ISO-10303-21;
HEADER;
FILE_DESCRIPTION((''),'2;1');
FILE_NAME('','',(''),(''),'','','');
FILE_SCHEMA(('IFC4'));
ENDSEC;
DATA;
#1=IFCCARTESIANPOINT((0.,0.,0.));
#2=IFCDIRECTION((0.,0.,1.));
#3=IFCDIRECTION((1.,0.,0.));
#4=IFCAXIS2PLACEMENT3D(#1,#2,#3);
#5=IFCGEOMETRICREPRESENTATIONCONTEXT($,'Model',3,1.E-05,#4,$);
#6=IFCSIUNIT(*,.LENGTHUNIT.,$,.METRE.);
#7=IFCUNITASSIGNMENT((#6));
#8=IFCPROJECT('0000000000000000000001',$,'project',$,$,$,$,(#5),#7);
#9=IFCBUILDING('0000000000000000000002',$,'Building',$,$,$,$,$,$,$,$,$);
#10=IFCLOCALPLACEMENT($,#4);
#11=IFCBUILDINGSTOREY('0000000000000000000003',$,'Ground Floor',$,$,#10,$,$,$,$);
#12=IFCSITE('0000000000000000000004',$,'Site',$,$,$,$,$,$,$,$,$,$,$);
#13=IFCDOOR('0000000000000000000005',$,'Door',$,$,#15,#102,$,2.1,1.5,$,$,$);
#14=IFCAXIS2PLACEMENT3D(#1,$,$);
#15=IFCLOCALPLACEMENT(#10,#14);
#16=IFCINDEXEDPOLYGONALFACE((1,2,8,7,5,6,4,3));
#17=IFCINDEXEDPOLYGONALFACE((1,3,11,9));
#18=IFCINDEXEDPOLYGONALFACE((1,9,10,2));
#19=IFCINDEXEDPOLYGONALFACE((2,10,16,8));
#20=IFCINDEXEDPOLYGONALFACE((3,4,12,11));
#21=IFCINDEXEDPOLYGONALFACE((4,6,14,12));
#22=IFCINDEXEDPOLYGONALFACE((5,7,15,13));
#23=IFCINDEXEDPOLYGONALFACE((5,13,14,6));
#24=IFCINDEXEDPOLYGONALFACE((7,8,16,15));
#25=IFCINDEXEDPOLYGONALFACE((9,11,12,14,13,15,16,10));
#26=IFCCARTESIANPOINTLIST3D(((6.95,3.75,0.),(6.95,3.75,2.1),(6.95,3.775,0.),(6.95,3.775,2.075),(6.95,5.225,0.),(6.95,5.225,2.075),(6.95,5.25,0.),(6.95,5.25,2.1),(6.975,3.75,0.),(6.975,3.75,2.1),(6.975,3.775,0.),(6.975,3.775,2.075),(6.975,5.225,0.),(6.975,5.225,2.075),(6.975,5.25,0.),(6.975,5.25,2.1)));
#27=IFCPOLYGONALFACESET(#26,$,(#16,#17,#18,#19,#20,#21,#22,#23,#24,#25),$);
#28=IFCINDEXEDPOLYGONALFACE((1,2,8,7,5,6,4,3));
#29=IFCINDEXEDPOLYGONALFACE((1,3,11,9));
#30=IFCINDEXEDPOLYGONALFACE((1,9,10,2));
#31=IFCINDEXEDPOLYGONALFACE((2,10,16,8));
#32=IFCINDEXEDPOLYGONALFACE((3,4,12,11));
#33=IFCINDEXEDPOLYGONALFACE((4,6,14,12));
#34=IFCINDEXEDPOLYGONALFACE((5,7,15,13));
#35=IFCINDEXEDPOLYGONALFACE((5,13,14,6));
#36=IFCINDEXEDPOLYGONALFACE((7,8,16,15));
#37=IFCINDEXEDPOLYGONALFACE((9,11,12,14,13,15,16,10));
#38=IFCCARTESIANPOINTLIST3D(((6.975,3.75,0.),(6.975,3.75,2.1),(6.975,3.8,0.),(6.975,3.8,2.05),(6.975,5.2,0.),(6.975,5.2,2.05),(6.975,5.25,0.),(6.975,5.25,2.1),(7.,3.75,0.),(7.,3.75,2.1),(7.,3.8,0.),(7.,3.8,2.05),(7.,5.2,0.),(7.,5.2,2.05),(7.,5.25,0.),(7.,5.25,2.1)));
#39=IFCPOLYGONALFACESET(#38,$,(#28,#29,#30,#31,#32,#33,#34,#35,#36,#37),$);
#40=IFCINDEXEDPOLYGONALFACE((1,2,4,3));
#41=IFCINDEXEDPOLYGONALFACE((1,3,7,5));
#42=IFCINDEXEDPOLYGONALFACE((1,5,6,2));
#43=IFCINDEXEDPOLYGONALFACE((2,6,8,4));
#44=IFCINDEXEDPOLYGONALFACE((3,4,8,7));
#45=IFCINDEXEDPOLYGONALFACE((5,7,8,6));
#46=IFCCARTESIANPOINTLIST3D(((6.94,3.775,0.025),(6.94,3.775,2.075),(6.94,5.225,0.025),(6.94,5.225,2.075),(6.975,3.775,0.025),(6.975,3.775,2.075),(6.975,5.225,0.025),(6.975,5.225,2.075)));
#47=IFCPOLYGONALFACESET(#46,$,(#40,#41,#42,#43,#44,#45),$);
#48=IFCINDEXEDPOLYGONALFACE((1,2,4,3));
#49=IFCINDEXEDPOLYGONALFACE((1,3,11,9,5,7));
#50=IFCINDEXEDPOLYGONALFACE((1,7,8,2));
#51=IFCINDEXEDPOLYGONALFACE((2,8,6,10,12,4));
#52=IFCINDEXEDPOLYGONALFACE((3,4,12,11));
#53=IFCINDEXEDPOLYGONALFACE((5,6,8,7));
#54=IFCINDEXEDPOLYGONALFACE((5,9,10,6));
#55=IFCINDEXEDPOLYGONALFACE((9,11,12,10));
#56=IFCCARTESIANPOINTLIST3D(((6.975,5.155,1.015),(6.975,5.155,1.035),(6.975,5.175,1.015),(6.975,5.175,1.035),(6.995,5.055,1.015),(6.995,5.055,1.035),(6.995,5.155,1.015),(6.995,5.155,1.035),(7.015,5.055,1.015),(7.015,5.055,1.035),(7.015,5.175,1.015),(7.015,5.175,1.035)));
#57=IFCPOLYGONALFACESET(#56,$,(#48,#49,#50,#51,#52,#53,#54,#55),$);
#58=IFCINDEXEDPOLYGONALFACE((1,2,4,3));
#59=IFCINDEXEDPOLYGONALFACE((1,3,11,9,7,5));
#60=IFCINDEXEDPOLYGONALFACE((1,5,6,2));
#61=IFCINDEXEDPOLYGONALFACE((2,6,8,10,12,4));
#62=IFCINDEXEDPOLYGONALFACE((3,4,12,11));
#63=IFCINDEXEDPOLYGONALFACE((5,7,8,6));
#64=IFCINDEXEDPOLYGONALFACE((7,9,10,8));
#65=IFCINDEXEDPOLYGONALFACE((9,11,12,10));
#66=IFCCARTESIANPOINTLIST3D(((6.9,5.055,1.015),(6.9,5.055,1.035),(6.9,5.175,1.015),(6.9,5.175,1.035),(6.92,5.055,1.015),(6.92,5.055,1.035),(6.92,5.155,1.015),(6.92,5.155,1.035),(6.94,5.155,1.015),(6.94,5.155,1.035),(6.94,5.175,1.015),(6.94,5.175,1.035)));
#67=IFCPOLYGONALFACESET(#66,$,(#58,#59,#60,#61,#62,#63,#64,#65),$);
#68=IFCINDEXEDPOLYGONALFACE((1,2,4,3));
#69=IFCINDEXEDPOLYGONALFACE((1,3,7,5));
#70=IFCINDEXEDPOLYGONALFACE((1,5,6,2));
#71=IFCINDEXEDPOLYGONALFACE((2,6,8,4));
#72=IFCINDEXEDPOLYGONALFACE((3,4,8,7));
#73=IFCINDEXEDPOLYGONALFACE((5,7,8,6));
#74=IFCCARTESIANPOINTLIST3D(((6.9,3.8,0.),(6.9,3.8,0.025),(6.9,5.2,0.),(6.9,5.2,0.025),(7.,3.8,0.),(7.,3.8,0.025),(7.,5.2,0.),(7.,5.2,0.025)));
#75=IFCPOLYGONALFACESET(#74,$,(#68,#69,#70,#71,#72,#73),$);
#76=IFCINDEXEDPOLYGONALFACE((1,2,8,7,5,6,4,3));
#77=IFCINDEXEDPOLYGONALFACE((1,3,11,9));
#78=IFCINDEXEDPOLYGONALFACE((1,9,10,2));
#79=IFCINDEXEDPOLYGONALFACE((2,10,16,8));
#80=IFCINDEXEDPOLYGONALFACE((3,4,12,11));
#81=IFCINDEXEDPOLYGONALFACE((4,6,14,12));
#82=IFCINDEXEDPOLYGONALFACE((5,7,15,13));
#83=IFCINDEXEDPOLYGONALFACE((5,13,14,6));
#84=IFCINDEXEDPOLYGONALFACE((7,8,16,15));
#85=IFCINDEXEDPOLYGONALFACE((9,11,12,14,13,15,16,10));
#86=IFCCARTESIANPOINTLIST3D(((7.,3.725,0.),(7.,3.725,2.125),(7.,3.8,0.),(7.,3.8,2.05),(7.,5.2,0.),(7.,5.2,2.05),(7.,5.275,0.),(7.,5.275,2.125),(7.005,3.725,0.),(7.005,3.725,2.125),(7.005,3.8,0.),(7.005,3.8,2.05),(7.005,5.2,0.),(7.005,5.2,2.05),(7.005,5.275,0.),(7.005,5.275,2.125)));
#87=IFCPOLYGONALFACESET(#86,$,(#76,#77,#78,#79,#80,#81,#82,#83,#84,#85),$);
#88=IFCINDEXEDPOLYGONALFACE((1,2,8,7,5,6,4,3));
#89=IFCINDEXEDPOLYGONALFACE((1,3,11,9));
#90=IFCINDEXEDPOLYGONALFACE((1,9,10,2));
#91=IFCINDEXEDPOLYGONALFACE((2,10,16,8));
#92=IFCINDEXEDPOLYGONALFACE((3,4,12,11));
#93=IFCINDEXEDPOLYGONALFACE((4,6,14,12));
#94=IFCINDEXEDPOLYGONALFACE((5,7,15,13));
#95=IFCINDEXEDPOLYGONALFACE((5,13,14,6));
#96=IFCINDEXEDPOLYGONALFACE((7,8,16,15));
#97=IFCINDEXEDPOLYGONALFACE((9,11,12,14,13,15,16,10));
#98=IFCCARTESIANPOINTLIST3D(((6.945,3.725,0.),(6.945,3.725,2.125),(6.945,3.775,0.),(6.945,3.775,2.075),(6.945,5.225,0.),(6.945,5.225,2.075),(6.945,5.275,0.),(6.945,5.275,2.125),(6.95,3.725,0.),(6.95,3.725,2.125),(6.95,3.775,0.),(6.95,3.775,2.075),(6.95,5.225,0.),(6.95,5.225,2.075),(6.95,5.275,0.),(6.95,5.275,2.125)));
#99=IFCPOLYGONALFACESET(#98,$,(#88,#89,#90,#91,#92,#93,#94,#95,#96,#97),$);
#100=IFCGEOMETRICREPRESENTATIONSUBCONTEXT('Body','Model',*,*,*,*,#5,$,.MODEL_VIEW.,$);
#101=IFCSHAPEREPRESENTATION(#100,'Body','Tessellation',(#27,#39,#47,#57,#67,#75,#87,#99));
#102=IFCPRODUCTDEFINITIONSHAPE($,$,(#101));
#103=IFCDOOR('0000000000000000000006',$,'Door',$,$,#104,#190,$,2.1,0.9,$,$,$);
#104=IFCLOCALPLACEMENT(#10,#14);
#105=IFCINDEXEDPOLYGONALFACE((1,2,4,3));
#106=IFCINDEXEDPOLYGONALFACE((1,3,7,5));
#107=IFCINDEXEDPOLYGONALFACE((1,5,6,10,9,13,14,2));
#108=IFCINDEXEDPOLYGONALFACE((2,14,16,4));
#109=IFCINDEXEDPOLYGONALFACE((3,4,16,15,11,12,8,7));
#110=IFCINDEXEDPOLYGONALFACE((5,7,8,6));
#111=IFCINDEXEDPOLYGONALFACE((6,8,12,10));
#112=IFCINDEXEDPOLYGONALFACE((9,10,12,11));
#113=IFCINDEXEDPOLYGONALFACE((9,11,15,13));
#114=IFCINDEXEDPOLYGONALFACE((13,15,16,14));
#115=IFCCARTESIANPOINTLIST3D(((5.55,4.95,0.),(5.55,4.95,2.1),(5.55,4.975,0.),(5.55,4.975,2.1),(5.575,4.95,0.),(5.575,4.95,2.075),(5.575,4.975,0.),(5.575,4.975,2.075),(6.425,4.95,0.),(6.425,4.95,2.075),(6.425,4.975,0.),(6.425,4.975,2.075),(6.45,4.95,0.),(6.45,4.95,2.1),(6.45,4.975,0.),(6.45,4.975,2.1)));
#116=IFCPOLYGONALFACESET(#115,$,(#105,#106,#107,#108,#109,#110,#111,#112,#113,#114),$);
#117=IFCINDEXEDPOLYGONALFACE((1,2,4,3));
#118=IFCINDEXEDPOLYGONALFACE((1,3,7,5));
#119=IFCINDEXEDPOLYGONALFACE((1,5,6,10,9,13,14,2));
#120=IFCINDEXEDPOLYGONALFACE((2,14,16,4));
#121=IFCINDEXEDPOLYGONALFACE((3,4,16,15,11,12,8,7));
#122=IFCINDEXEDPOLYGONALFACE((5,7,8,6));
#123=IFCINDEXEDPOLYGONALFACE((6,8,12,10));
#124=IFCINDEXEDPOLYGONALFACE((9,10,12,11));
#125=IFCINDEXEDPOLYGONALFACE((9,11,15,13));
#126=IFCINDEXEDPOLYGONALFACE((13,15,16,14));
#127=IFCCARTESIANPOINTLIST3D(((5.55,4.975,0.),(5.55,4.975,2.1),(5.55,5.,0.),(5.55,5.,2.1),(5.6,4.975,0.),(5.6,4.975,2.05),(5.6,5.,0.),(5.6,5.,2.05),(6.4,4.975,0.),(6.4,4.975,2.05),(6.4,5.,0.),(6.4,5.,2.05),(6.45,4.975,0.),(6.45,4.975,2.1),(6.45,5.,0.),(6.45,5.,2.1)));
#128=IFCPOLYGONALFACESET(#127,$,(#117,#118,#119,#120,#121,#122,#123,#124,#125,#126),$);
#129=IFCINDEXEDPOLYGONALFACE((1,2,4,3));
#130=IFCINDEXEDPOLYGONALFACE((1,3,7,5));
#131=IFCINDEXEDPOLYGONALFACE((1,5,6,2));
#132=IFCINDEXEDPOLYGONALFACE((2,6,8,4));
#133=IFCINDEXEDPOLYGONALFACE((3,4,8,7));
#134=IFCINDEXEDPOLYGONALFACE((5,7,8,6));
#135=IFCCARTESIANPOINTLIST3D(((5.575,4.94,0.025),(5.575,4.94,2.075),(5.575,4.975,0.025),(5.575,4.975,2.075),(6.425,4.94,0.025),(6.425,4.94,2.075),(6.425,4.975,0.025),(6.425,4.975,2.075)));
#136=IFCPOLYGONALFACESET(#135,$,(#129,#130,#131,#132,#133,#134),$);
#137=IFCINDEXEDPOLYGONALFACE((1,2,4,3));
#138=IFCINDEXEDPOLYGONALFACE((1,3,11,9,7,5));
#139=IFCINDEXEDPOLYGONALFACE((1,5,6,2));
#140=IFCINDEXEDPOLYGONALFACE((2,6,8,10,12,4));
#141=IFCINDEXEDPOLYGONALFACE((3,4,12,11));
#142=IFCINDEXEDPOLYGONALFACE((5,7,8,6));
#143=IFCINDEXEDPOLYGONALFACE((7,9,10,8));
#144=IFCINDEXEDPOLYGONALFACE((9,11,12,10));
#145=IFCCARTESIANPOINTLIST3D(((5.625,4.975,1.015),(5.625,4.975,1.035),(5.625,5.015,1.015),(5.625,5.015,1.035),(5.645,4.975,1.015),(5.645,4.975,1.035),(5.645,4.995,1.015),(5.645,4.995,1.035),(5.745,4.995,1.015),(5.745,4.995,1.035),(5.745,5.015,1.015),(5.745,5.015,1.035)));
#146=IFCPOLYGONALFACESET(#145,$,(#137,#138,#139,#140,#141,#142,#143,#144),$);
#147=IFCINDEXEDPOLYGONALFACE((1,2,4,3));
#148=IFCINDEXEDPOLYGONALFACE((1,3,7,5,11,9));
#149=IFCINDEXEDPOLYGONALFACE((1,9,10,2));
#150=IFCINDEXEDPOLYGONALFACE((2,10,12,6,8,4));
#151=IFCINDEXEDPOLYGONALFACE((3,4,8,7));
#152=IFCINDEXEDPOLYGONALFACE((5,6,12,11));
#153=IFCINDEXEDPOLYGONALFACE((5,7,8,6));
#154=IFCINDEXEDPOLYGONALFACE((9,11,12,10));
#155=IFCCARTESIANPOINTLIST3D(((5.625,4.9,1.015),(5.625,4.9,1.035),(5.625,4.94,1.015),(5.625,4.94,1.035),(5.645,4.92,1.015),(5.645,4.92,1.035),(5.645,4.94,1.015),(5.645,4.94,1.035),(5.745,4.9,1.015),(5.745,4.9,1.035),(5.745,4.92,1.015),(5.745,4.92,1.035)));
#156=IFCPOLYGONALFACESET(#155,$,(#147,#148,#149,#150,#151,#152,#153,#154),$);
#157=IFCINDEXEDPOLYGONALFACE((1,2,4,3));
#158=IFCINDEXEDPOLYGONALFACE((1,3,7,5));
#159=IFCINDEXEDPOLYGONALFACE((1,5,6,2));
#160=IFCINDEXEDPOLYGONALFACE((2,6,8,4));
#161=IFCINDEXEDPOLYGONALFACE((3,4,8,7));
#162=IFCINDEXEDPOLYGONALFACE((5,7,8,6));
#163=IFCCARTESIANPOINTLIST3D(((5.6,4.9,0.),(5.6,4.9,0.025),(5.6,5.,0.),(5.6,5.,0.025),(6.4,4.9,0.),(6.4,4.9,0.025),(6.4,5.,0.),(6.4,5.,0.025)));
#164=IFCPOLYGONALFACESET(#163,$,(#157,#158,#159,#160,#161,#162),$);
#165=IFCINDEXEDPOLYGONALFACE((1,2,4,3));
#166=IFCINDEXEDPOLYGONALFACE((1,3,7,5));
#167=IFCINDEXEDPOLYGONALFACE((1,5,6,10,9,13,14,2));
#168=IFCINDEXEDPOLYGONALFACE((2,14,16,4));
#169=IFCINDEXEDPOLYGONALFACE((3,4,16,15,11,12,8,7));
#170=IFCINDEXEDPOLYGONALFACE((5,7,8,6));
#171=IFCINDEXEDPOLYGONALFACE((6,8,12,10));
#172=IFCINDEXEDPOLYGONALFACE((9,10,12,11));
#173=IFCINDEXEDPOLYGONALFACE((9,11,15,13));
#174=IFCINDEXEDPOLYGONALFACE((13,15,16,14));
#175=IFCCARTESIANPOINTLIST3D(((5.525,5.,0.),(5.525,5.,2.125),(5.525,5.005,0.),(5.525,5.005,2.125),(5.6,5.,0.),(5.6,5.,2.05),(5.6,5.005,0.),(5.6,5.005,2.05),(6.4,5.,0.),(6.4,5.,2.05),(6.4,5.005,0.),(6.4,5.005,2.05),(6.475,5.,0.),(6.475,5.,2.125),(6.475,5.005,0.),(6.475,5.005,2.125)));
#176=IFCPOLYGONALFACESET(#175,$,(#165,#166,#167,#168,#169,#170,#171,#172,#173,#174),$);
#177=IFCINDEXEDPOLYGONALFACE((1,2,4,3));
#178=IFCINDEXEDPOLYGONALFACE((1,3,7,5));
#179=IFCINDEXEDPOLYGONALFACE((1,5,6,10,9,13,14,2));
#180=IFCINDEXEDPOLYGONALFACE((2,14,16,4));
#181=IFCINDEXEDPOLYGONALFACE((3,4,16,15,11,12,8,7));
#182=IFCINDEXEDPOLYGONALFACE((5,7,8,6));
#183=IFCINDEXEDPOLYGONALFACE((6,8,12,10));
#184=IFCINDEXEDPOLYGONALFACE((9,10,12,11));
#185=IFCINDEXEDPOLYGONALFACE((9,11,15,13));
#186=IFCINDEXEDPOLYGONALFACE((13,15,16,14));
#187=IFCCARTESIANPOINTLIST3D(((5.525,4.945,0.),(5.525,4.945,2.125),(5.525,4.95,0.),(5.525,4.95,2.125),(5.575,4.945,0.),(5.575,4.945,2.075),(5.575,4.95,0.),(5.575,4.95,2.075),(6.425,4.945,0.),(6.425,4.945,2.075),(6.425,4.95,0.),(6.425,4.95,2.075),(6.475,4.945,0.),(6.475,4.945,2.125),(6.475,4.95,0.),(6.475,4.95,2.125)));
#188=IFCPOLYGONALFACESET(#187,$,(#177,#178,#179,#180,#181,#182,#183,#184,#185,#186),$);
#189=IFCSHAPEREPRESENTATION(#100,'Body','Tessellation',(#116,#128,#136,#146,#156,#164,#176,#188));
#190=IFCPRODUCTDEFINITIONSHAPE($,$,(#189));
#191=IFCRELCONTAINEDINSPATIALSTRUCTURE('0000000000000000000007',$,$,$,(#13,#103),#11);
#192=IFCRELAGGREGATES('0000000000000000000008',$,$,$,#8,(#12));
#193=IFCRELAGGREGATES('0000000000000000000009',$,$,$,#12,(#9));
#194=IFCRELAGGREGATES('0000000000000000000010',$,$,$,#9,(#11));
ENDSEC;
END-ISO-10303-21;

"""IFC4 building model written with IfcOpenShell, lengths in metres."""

from ifc_helpers import new_model, si_unit, frame, origin_with_axes, place, context, subcontext, project, spatial, line, indexed_curve, outline, extrude, element, save


model = new_model("IFC4")

# Units and contexts
model_context = context("Model", 3, precision=1e-05, world=origin_with_axes())
body_context = subcontext(model_context, "Body", "Model", "MODEL_VIEW")
ifc_project = project(units=[si_unit("LENGTHUNIT", "METRE")], contexts=[model_context])

# Site, building, storey
site = spatial("IfcSite", under=ifc_project, Name="Site")
building = spatial("IfcBuilding", under=site, Name="Building")
storey_placement = place(None, origin_with_axes())
storey = spatial("IfcBuildingStorey", under=building, at=storey_placement, Name="Ground Floor")

# Doors
door_1_placement = place(storey_placement, frame((7.0, 3.75, 0.0), z_axis=(0.0, 0.0, 1.0), x_axis=(0.0, 1.0, 0.0)))
element("IfcDoor", 1, at=door_1_placement, inside=storey, Name="Door", OverallHeight=2.1, OverallWidth=1.5, context=body_context, shape_type="SweptSolid", body=[
    extrude(outline(indexed_curve([(0.0, 0.0), (0.0, 2.1), (1.5, 2.1), (1.5, 0.0), (1.475, 0.0), (1.475, 2.075), (0.025, 2.075), (0.025, 0.0)], segments=[line(1, 2, 3, 4, 5, 6, 7, 8, 1)])), frame((0.0, 0.025, 0.0), z_axis=(0.0, -1.0, 0.0), x_axis=(1.0, 0.0, 0.0)), (0.0, 0.0, -1.0), 0.025),
    extrude(outline(indexed_curve([(0.0, 0.0), (0.0, 2.1), (1.5, 2.1), (1.5, 0.0), (1.45, 0.0), (1.45, 2.05), (0.05, 2.05), (0.05, 0.0)], segments=[line(1, 2, 3, 4, 5, 6, 7, 8, 1)])), frame((0.0, 0.0, 0.0), z_axis=(0.0, -1.0, 0.0), x_axis=(1.0, 0.0, 0.0)), (0.0, 0.0, -1.0), 0.025),
    extrude(outline(indexed_curve([(0.0, 0.0), (1.45, 0.0), (1.45, 0.035), (0.0, 0.035)], segments=[line(1, 2, 3, 4, 1)])), frame((0.025, 0.025, 0.025), z_axis=(0.0, 0.0, 1.0), x_axis=(1.0, 0.0, 0.0)), (0.0, 0.0, 1.0), 2.05),
    extrude(outline(indexed_curve([(0.0, 0.0), (0.0, -0.04), (-0.12, -0.04), (-0.12, -0.02), (-0.02, -0.02), (-0.02, 0.0)], segments=[line(1, 2, 3, 4, 5, 6, 1)])), frame((1.425, 0.025, 1.015), z_axis=(0.0, 0.0, 1.0), x_axis=(1.0, 0.0, 0.0)), (0.0, 0.0, 1.0), 0.02),
    extrude(outline(indexed_curve([(0.0, 0.0), (0.0, 0.04), (-0.12, 0.04), (-0.12, 0.02), (-0.02, 0.02), (-0.02, 0.0)], segments=[line(1, 2, 3, 4, 5, 6, 1)])), frame((1.425, 0.06, 1.015), z_axis=(0.0, 0.0, 1.0), x_axis=(1.0, 0.0, 0.0)), (0.0, 0.0, 1.0), 0.02),
    extrude(outline(indexed_curve([(0.0, 0.0), (1.4, 0.0), (1.4, 0.1), (0.0, 0.1)], segments=[line(1, 2, 3, 4, 1)])), frame((0.05, 0.0, 0.0), z_axis=(0.0, 0.0, 1.0), x_axis=(1.0, 0.0, 0.0)), (0.0, 0.0, 1.0), 0.025),
    extrude(outline(indexed_curve([(0.0, 0.0), (0.0, 2.125), (1.55, 2.125), (1.55, 0.0), (1.475, 0.0), (1.475, 2.05), (0.075, 2.05), (0.075, 0.0)], segments=[line(1, 2, 3, 4, 5, 6, 7, 8, 1)])), frame((-0.025, -0.005, 0.0), z_axis=(0.0, -1.0, 0.0), x_axis=(1.0, 0.0, 0.0)), (0.0, 0.0, -1.0), 0.005),
    extrude(outline(indexed_curve([(0.0, 0.0), (0.0, 2.125), (1.55, 2.125), (1.55, 0.0), (1.5, 0.0), (1.5, 2.075), (0.05, 2.075), (0.05, 0.0)], segments=[line(1, 2, 3, 4, 5, 6, 7, 8, 1)])), frame((-0.025, 0.05, 0.0), z_axis=(0.0, -1.0, 0.0), x_axis=(1.0, 0.0, 0.0)), (0.0, 0.0, -1.0), 0.005),
])
door_2_placement = place(storey_placement, frame((6.45, 5.0, 0.0), z_axis=(0.0, 0.0, 1.0), x_axis=(-1.0, 0.0, 0.0)))
element("IfcDoor", 2, at=door_2_placement, inside=storey, Name="Door", OverallHeight=2.1, OverallWidth=0.9, context=body_context, shape_type="SweptSolid", body=[
    extrude(outline(indexed_curve([(0.0, 0.0), (0.0, 2.1), (0.9, 2.1), (0.9, 0.0), (0.875, 0.0), (0.875, 2.075), (0.025, 2.075), (0.025, 0.0)], segments=[line(1, 2, 3, 4, 5, 6, 7, 8, 1)])), frame((0.0, 0.025, 0.0), z_axis=(0.0, -1.0, 0.0), x_axis=(1.0, 0.0, 0.0)), (0.0, 0.0, -1.0), 0.025),
    extrude(outline(indexed_curve([(0.0, 0.0), (0.0, 2.1), (0.9, 2.1), (0.9, 0.0), (0.85, 0.0), (0.85, 2.05), (0.05, 2.05), (0.05, 0.0)], segments=[line(1, 2, 3, 4, 5, 6, 7, 8, 1)])), frame((0.0, 0.0, 0.0), z_axis=(0.0, -1.0, 0.0), x_axis=(1.0, 0.0, 0.0)), (0.0, 0.0, -1.0), 0.025),
    extrude(outline(indexed_curve([(0.0, 0.0), (0.85, 0.0), (0.85, 0.035), (0.0, 0.035)], segments=[line(1, 2, 3, 4, 1)])), frame((0.025, 0.025, 0.025), z_axis=(0.0, 0.0, 1.0), x_axis=(1.0, 0.0, 0.0)), (0.0, 0.0, 1.0), 2.05),
    extrude(outline(indexed_curve([(0.0, 0.0), (0.0, -0.04), (-0.12, -0.04), (-0.12, -0.02), (-0.02, -0.02), (-0.02, 0.0)], segments=[line(1, 2, 3, 4, 5, 6, 1)])), frame((0.825, 0.025, 1.015), z_axis=(0.0, 0.0, 1.0), x_axis=(1.0, 0.0, 0.0)), (0.0, 0.0, 1.0), 0.02),
    extrude(outline(indexed_curve([(0.0, 0.0), (0.0, 0.04), (-0.12, 0.04), (-0.12, 0.02), (-0.02, 0.02), (-0.02, 0.0)], segments=[line(1, 2, 3, 4, 5, 6, 1)])), frame((0.825, 0.06, 1.015), z_axis=(0.0, 0.0, 1.0), x_axis=(1.0, 0.0, 0.0)), (0.0, 0.0, 1.0), 0.02),
    extrude(outline(indexed_curve([(0.0, 0.0), (0.8, 0.0), (0.8, 0.1), (0.0, 0.1)], segments=[line(1, 2, 3, 4, 1)])), frame((0.05, 0.0, 0.0), z_axis=(0.0, 0.0, 1.0), x_axis=(1.0, 0.0, 0.0)), (0.0, 0.0, 1.0), 0.025),
    extrude(outline(indexed_curve([(0.0, 0.0), (0.0, 2.125), (0.95, 2.125), (0.95, 0.0), (0.875, 0.0), (0.875, 2.05), (0.075, 2.05), (0.075, 0.0)], segments=[line(1, 2, 3, 4, 5, 6, 7, 8, 1)])), frame((-0.025, -0.005, 0.0), z_axis=(0.0, -1.0, 0.0), x_axis=(1.0, 0.0, 0.0)), (0.0, 0.0, -1.0), 0.005),
    extrude(outline(indexed_curve([(0.0, 0.0), (0.0, 2.125), (0.95, 2.125), (0.95, 0.0), (0.9, 0.0), (0.9, 2.075), (0.05, 2.075), (0.05, 0.0)], segments=[line(1, 2, 3, 4, 5, 6, 7, 8, 1)])), frame((-0.025, 0.05, 0.0), z_axis=(0.0, -1.0, 0.0), x_axis=(1.0, 0.0, 0.0)), (0.0, 0.0, -1.0), 0.005),
])

save(model, "model.ifc")
